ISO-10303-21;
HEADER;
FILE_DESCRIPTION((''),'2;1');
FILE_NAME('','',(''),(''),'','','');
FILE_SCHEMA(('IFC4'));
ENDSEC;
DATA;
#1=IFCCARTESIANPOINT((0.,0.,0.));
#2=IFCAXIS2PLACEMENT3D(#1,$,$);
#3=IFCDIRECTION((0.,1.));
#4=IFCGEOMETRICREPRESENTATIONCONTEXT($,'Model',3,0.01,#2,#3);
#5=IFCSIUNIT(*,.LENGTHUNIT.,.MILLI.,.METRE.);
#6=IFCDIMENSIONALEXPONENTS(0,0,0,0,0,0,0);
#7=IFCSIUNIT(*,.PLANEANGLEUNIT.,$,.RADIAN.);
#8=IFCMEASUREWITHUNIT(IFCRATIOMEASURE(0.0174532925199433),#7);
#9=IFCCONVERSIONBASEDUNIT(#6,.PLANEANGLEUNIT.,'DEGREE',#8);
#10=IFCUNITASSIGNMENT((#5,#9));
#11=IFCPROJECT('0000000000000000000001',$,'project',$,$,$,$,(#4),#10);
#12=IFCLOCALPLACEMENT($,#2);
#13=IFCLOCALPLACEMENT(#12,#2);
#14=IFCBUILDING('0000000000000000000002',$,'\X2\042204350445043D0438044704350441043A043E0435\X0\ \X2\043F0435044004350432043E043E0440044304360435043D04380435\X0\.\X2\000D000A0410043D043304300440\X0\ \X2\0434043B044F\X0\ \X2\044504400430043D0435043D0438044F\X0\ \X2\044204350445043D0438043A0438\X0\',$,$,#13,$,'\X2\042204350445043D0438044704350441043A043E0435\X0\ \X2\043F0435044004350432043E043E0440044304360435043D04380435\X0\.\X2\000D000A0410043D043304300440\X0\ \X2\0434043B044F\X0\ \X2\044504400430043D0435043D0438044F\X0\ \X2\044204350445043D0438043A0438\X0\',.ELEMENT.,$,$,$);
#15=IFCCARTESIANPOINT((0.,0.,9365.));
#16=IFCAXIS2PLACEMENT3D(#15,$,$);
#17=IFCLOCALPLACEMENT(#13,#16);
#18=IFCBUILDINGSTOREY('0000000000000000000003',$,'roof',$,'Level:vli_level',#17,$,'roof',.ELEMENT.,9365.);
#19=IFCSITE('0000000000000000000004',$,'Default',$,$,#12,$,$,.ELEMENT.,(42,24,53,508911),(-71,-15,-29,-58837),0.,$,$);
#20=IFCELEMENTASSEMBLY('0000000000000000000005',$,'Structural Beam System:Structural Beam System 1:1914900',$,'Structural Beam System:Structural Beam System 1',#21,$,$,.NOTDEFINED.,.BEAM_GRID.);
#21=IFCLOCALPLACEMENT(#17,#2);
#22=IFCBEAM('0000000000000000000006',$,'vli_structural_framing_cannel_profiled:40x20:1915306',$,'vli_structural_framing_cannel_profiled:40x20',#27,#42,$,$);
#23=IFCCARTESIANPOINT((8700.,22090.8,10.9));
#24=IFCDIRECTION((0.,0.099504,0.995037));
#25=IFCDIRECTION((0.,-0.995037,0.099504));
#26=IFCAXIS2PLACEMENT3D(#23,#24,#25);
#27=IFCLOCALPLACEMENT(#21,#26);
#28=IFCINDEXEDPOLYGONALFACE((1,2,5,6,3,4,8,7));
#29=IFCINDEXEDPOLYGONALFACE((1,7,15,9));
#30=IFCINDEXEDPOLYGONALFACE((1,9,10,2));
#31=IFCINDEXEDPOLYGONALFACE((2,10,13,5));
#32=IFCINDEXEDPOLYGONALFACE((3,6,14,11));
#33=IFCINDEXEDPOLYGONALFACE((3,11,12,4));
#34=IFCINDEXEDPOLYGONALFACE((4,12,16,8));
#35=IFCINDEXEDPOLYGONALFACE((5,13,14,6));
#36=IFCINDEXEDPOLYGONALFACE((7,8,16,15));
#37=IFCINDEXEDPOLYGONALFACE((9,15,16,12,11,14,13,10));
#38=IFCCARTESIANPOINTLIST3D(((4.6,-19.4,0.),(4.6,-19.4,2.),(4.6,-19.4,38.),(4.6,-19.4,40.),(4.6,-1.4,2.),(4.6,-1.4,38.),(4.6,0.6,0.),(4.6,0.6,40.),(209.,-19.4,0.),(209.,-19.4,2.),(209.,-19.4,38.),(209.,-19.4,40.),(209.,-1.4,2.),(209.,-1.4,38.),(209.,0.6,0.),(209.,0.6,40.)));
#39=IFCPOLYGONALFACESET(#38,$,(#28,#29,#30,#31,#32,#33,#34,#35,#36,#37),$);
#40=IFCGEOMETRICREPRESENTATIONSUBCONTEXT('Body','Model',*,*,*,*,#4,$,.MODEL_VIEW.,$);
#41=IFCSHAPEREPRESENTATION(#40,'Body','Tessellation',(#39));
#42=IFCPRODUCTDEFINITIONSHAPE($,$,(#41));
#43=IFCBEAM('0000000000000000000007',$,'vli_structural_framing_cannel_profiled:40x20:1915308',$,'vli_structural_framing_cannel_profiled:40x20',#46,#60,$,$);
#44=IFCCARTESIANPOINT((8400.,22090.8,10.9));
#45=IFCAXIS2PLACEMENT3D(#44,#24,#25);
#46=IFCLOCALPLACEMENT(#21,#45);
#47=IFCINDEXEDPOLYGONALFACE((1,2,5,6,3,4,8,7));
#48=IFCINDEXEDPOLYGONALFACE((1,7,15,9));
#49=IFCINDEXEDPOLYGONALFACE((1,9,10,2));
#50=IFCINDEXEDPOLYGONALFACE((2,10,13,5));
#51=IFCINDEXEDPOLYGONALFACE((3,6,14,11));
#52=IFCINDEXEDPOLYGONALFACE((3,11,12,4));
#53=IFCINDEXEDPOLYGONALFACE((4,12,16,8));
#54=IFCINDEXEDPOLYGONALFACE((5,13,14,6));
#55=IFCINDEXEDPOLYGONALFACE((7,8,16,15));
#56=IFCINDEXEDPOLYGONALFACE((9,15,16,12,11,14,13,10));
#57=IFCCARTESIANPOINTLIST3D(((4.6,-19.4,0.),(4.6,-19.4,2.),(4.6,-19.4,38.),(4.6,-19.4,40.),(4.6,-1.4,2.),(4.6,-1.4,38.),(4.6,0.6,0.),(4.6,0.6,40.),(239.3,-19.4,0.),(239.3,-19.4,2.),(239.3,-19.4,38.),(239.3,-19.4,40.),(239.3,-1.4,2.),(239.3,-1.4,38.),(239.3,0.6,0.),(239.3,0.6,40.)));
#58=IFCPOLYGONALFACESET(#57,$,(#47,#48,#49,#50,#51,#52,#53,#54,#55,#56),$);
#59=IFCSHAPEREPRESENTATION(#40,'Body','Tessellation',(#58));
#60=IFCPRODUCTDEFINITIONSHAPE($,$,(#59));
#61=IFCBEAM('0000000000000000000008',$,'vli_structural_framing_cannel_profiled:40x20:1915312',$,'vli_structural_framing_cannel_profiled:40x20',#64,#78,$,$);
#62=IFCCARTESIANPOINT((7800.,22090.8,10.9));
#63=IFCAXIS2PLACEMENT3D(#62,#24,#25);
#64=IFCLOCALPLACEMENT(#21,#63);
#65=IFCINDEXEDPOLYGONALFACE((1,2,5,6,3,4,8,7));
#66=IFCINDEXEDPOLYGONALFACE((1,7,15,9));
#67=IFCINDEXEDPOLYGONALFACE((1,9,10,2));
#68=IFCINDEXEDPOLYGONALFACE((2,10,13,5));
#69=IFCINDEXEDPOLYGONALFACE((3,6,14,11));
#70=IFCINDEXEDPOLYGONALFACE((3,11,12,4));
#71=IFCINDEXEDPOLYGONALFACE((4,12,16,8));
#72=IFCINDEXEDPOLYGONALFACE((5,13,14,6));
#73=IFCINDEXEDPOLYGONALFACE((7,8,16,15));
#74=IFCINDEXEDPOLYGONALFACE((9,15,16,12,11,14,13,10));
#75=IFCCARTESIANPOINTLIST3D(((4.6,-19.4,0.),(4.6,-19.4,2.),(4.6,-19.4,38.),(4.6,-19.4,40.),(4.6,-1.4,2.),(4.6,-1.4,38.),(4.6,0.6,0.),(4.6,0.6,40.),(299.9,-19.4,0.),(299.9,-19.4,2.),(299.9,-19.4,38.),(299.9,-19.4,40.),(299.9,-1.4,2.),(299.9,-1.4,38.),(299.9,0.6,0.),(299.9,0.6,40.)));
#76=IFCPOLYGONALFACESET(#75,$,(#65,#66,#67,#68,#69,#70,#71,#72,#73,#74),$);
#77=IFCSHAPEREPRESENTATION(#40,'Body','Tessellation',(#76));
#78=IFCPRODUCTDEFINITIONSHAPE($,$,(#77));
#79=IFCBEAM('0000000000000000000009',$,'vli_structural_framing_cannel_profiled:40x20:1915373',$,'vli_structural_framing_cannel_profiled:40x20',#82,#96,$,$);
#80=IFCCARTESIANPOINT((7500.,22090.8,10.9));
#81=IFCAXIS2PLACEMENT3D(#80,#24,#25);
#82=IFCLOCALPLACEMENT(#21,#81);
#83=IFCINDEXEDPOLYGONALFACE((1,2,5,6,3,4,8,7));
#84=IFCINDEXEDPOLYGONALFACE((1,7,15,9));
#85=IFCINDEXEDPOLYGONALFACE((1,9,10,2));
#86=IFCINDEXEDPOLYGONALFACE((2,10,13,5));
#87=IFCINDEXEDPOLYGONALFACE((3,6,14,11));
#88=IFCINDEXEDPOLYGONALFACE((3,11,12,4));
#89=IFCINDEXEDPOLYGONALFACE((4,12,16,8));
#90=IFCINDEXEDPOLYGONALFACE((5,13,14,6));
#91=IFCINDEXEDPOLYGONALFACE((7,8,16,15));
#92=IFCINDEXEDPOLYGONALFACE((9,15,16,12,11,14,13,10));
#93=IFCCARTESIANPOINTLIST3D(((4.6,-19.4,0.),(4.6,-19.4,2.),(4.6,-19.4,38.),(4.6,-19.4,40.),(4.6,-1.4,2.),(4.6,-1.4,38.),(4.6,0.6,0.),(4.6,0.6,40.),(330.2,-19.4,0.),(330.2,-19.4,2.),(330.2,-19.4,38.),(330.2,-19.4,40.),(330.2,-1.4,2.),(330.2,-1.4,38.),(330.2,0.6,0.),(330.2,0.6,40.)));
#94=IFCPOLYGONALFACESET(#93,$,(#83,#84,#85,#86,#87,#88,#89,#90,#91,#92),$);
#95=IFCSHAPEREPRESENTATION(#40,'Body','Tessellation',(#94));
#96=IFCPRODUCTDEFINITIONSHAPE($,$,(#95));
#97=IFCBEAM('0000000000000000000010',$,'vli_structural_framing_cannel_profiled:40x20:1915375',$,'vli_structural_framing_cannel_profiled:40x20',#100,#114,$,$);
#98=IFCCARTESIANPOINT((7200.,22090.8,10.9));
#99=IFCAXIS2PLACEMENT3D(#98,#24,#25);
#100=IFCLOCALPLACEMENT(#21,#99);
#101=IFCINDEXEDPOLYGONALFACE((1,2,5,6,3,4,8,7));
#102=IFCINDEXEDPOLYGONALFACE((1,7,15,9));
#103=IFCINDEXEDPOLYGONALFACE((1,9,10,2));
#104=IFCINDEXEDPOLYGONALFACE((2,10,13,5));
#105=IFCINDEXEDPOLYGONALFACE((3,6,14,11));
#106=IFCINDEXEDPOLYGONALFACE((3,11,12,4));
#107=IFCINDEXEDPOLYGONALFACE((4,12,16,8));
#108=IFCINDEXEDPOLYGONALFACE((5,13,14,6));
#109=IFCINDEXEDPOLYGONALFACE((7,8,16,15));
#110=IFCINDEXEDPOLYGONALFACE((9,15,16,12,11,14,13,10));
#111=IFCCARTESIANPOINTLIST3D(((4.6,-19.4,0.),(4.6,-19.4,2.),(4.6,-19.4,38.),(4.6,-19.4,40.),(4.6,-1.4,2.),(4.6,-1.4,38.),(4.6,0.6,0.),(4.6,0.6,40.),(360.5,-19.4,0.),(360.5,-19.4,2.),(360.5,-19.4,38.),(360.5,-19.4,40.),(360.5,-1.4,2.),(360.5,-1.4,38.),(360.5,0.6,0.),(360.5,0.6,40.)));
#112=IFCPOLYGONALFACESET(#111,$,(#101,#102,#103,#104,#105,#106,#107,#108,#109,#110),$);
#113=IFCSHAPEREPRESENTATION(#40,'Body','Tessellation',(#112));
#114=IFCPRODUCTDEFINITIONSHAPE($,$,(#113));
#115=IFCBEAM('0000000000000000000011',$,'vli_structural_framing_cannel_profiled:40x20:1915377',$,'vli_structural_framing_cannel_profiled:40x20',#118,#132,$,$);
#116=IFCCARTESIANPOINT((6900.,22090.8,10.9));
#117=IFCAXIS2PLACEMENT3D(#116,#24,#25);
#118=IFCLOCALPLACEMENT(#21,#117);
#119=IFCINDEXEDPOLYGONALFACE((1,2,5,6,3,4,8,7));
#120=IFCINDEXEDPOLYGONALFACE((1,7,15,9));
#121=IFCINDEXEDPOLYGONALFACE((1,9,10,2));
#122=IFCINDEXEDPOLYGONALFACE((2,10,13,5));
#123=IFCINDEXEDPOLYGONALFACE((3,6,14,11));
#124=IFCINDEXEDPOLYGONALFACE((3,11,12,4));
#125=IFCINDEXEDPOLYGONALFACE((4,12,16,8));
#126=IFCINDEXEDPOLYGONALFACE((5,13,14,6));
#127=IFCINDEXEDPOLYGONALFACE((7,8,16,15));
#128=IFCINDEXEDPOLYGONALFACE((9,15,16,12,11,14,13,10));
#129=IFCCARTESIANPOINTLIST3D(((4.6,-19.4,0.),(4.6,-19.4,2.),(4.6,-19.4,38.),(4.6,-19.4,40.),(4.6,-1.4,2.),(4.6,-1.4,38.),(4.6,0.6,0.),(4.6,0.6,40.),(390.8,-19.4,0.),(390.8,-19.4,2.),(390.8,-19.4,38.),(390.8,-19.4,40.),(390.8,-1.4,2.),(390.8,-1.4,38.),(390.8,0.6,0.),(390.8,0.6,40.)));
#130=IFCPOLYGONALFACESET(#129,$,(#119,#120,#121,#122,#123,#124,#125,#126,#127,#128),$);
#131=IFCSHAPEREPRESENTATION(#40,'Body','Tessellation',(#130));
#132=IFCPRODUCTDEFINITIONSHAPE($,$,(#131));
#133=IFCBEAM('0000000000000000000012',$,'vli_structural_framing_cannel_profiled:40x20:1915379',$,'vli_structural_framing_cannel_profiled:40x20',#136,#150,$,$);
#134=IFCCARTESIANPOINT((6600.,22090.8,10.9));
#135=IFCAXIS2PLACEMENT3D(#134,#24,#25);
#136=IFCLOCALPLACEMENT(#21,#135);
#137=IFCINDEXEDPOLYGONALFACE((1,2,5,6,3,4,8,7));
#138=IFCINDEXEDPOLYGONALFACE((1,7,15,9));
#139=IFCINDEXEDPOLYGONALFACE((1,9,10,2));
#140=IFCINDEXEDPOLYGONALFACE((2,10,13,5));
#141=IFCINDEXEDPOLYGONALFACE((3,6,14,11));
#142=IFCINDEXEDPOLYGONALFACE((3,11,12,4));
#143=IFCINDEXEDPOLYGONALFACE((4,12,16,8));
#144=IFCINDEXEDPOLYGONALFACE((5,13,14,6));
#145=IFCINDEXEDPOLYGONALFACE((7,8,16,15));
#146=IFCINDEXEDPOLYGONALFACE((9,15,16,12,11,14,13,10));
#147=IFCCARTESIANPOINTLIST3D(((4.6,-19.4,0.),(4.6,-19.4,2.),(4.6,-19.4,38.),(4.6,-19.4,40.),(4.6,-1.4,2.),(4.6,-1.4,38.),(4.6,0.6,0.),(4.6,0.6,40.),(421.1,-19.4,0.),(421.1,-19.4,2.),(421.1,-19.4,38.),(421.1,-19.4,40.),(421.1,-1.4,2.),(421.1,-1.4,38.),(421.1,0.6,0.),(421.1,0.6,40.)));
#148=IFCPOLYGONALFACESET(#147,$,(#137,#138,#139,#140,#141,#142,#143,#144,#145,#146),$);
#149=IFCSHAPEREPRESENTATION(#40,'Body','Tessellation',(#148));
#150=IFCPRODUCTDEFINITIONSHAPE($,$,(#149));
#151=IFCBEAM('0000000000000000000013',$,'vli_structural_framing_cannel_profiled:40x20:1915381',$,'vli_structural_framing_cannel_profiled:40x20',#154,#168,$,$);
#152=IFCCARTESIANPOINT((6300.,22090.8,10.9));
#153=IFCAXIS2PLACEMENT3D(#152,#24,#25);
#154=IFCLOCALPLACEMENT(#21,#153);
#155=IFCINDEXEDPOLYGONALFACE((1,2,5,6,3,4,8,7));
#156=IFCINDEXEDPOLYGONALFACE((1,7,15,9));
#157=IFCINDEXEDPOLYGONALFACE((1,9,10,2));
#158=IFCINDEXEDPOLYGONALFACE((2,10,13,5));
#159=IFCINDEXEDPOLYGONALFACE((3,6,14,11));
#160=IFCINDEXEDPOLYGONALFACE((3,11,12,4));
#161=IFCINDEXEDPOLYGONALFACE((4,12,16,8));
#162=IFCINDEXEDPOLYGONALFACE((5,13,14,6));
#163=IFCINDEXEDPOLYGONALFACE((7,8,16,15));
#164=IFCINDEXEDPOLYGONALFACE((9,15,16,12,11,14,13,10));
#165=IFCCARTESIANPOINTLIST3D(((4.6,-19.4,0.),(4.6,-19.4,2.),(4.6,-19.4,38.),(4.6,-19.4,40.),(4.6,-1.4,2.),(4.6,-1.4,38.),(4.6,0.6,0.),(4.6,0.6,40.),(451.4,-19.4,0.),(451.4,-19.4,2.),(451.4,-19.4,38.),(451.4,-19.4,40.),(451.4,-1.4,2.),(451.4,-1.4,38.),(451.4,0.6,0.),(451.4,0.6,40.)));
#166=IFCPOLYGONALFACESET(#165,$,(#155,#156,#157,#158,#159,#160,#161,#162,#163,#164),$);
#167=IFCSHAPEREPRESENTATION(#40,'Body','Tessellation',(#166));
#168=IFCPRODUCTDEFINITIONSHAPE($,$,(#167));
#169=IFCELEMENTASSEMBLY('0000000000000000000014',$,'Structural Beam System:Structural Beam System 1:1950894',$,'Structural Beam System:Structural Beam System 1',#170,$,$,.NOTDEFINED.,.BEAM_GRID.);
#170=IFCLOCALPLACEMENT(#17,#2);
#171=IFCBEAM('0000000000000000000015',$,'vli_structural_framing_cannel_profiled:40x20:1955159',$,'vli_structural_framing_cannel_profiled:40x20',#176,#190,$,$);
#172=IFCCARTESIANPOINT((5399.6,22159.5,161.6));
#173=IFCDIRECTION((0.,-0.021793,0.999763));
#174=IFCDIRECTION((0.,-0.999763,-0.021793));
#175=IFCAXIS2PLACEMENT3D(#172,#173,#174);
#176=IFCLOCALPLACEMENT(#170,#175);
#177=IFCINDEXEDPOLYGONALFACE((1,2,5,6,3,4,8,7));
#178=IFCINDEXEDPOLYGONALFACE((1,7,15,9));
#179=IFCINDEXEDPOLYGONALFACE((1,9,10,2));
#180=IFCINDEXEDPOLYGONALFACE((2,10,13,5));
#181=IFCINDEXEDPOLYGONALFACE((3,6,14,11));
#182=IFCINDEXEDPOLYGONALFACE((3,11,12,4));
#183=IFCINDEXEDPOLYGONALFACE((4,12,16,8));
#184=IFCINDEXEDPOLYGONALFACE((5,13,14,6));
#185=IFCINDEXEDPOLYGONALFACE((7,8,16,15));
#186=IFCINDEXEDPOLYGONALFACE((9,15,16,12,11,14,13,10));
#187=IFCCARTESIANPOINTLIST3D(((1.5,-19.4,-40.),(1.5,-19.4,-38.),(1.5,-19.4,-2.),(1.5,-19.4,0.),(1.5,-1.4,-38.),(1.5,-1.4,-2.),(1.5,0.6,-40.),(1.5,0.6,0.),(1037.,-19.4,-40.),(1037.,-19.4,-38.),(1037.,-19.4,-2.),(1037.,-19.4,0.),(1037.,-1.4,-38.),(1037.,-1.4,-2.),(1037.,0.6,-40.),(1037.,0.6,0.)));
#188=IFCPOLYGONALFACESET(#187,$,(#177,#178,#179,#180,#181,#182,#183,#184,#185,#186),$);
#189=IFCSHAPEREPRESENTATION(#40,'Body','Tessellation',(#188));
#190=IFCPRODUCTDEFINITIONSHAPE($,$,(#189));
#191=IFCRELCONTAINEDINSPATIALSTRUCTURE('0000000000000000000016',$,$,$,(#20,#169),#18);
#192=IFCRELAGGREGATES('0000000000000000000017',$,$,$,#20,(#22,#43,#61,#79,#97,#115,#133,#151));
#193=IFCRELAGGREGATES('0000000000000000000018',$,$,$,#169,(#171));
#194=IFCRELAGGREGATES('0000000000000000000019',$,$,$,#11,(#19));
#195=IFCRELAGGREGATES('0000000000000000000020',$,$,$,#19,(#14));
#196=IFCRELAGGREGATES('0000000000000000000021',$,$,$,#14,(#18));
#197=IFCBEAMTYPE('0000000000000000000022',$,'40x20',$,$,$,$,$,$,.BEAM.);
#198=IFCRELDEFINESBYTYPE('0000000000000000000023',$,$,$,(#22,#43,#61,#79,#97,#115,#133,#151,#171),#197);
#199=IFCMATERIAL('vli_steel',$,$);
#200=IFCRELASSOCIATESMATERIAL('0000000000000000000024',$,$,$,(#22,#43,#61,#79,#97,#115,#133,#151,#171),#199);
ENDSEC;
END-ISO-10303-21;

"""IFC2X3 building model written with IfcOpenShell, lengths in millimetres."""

from ifc_helpers import new_model, entity, si_unit, converted_unit, direction, frame, origin, place, context, subcontext, project, spatial, polyline, outline, extrude, material, type_object, element, aggregate, save


model = new_model("IFC2X3")

# Units and contexts
model_context = context("Model", 3, precision=0.01, world=origin(), true_north=direction((0.0, 1.0)))
body_context = subcontext(model_context, "Body", "Model", "MODEL_VIEW")
ifc_project = project(units=[si_unit("LENGTHUNIT", "METRE", prefix="MILLI"), converted_unit("PLANEANGLEUNIT", "DEGREE", entity("IfcRatioMeasure", 0.0174532925199433), si_unit("PLANEANGLEUNIT", "RADIAN"), dimensions=[0, 0, 0, 0, 0, 0, 0])], contexts=[model_context])

# Site, building, storey
site_placement = place(None, origin())
site = spatial("IfcSite", under=ifc_project, at=site_placement, Name="Default", CompositionType="ELEMENT", RefLatitude=(42, 24, 53, 508911), RefLongitude=(-71, -15, -29, -58837), RefElevation=0.0)
building_placement = place(site_placement, origin())
building = spatial("IfcBuilding", under=site, at=building_placement, Name="Техническое перевооружение.\r\nАнгар для хранения техники", LongName="Техническое перевооружение.\r\nАнгар для хранения техники", CompositionType="ELEMENT")
storey_placement = place(building_placement, frame((0.0, 0.0, 9365.0)))
storey = spatial("IfcBuildingStorey", under=building, at=storey_placement, Name="roof", ObjectType="Level:vli_level", LongName="roof", CompositionType="ELEMENT", Elevation=9365.0)

# Element assemblies, beams
assembly_1_placement = place(storey_placement, origin())
assembly_1 = element("IfcElementAssembly", 1, at=assembly_1_placement, inside=storey, Name="Structural Beam System:Structural Beam System 1:1914900", ObjectType="Structural Beam System:Structural Beam System 1", AssemblyPlace="NOTDEFINED", PredefinedType="BEAM_GRID")
ifc_material = material(Name="vli_steel")
beam_type = type_object("IfcBeamType", Name="40x20", PredefinedType="BEAM")
beam_1_placement = place(assembly_1_placement, frame((8700.0, 22090.8, 10.9), z_axis=(0.0, 0.099504, 0.995037), x_axis=(0.0, -0.995037, 0.099504)))
beam_1 = element("IfcBeam", 2, at=beam_1_placement, type_object=beam_type, material=ifc_material, Name="vli_structural_framing_cannel_profiled:40x20:1915306", ObjectType="vli_structural_framing_cannel_profiled:40x20", context=body_context, shape_type="SweptSolid", body=[
    extrude(outline(polyline([(-20.0, -9.5), (-18.0, -9.5), (-18.0, 8.5), (18.0, 8.5), (18.0, -9.5), (20.0, -9.5), (20.0, 10.5), (-20.0, 10.5), (-20.0, -9.5)])), frame((4.6, -9.9, 20.0), z_axis=(1.0, 0.0, 0.0), x_axis=(0.0, 0.0, -1.0)), (0.0, 0.0, 1.0), 204.4),
])
beam_2_placement = place(assembly_1_placement, frame((8400.0, 22090.8, 10.9), z_axis=(0.0, 0.099504, 0.995037), x_axis=(0.0, -0.995037, 0.099504)))
beam_2 = element("IfcBeam", 3, at=beam_2_placement, type_object=beam_type, material=ifc_material, Name="vli_structural_framing_cannel_profiled:40x20:1915308", ObjectType="vli_structural_framing_cannel_profiled:40x20", context=body_context, shape_type="SweptSolid", body=[
    extrude(outline(polyline([(-20.0, -9.5), (-18.0, -9.5), (-18.0, 8.5), (18.0, 8.5), (18.0, -9.5), (20.0, -9.5), (20.0, 10.5), (-20.0, 10.5), (-20.0, -9.5)])), frame((4.6, -9.9, 20.0), z_axis=(1.0, 0.0, 0.0), x_axis=(0.0, 0.0, -1.0)), (0.0, 0.0, 1.0), 234.7),
])
beam_3_placement = place(assembly_1_placement, frame((7800.0, 22090.8, 10.9), z_axis=(0.0, 0.099504, 0.995037), x_axis=(0.0, -0.995037, 0.099504)))
beam_3 = element("IfcBeam", 4, at=beam_3_placement, type_object=beam_type, material=ifc_material, Name="vli_structural_framing_cannel_profiled:40x20:1915312", ObjectType="vli_structural_framing_cannel_profiled:40x20", context=body_context, shape_type="SweptSolid", body=[
    extrude(outline(polyline([(-20.0, -9.5), (-18.0, -9.5), (-18.0, 8.5), (18.0, 8.5), (18.0, -9.5), (20.0, -9.5), (20.0, 10.5), (-20.0, 10.5), (-20.0, -9.5)])), frame((4.6, -9.9, 20.0), z_axis=(1.0, 0.0, 0.0), x_axis=(0.0, 0.0, -1.0)), (0.0, 0.0, 1.0), 295.3),
])
beam_4_placement = place(assembly_1_placement, frame((7500.0, 22090.8, 10.9), z_axis=(0.0, 0.099504, 0.995037), x_axis=(0.0, -0.995037, 0.099504)))
beam_4 = element("IfcBeam", 5, at=beam_4_placement, type_object=beam_type, material=ifc_material, Name="vli_structural_framing_cannel_profiled:40x20:1915373", ObjectType="vli_structural_framing_cannel_profiled:40x20", context=body_context, shape_type="SweptSolid", body=[
    extrude(outline(polyline([(-20.0, -9.5), (-18.0, -9.5), (-18.0, 8.5), (18.0, 8.5), (18.0, -9.5), (20.0, -9.5), (20.0, 10.5), (-20.0, 10.5), (-20.0, -9.5)])), frame((4.6, -9.9, 20.0), z_axis=(1.0, 0.0, 0.0), x_axis=(0.0, 0.0, -1.0)), (0.0, 0.0, 1.0), 325.6),
])
beam_5_placement = place(assembly_1_placement, frame((7200.0, 22090.8, 10.9), z_axis=(0.0, 0.099504, 0.995037), x_axis=(0.0, -0.995037, 0.099504)))
beam_5 = element("IfcBeam", 6, at=beam_5_placement, type_object=beam_type, material=ifc_material, Name="vli_structural_framing_cannel_profiled:40x20:1915375", ObjectType="vli_structural_framing_cannel_profiled:40x20", context=body_context, shape_type="SweptSolid", body=[
    extrude(outline(polyline([(-20.0, -9.5), (-18.0, -9.5), (-18.0, 8.5), (18.0, 8.5), (18.0, -9.5), (20.0, -9.5), (20.0, 10.5), (-20.0, 10.5), (-20.0, -9.5)])), frame((4.6, -9.9, 20.0), z_axis=(1.0, 0.0, 0.0), x_axis=(0.0, 0.0, -1.0)), (0.0, 0.0, 1.0), 355.9),
])
beam_6_placement = place(assembly_1_placement, frame((6900.0, 22090.8, 10.9), z_axis=(0.0, 0.099504, 0.995037), x_axis=(0.0, -0.995037, 0.099504)))
beam_6 = element("IfcBeam", 7, at=beam_6_placement, type_object=beam_type, material=ifc_material, Name="vli_structural_framing_cannel_profiled:40x20:1915377", ObjectType="vli_structural_framing_cannel_profiled:40x20", context=body_context, shape_type="SweptSolid", body=[
    extrude(outline(polyline([(-20.0, -9.5), (-18.0, -9.5), (-18.0, 8.5), (18.0, 8.5), (18.0, -9.5), (20.0, -9.5), (20.0, 10.5), (-20.0, 10.5), (-20.0, -9.5)])), frame((4.6, -9.9, 20.0), z_axis=(1.0, 0.0, 0.0), x_axis=(0.0, 0.0, -1.0)), (0.0, 0.0, 1.0), 386.2),
])
beam_7_placement = place(assembly_1_placement, frame((6600.0, 22090.8, 10.9), z_axis=(0.0, 0.099504, 0.995037), x_axis=(0.0, -0.995037, 0.099504)))
beam_7 = element("IfcBeam", 8, at=beam_7_placement, type_object=beam_type, material=ifc_material, Name="vli_structural_framing_cannel_profiled:40x20:1915379", ObjectType="vli_structural_framing_cannel_profiled:40x20", context=body_context, shape_type="SweptSolid", body=[
    extrude(outline(polyline([(-20.0, -9.5), (-18.0, -9.5), (-18.0, 8.5), (18.0, 8.5), (18.0, -9.5), (20.0, -9.5), (20.0, 10.5), (-20.0, 10.5), (-20.0, -9.5)])), frame((4.6, -9.9, 20.0), z_axis=(1.0, 0.0, 0.0), x_axis=(0.0, 0.0, -1.0)), (0.0, 0.0, 1.0), 416.5),
])
beam_8_placement = place(assembly_1_placement, frame((6300.0, 22090.8, 10.9), z_axis=(0.0, 0.099504, 0.995037), x_axis=(0.0, -0.995037, 0.099504)))
beam_8 = element("IfcBeam", 9, at=beam_8_placement, type_object=beam_type, material=ifc_material, Name="vli_structural_framing_cannel_profiled:40x20:1915381", ObjectType="vli_structural_framing_cannel_profiled:40x20", context=body_context, shape_type="SweptSolid", body=[
    extrude(outline(polyline([(-20.0, -9.5), (-18.0, -9.5), (-18.0, 8.5), (18.0, 8.5), (18.0, -9.5), (20.0, -9.5), (20.0, 10.5), (-20.0, 10.5), (-20.0, -9.5)])), frame((4.6, -9.9, 20.0), z_axis=(1.0, 0.0, 0.0), x_axis=(0.0, 0.0, -1.0)), (0.0, 0.0, 1.0), 446.8),
])
aggregate(assembly_1, [beam_1, beam_2, beam_3, beam_4, beam_5, beam_6, beam_7, beam_8])
assembly_2_placement = place(storey_placement, origin())
assembly_2 = element("IfcElementAssembly", 10, at=assembly_2_placement, inside=storey, Name="Structural Beam System:Structural Beam System 1:1950894", ObjectType="Structural Beam System:Structural Beam System 1", AssemblyPlace="NOTDEFINED", PredefinedType="BEAM_GRID")
beam_9_placement = place(assembly_2_placement, frame((5399.6, 22159.5, 161.6), z_axis=(0.0, -0.021793, 0.999763), x_axis=(0.0, -0.999763, -0.021793)))
beam_9 = element("IfcBeam", 11, at=beam_9_placement, type_object=beam_type, material=ifc_material, Name="vli_structural_framing_cannel_profiled:40x20:1955159", ObjectType="vli_structural_framing_cannel_profiled:40x20", context=body_context, shape_type="SweptSolid", body=[
    extrude(outline(polyline([(-20.0, -9.5), (-18.0, -9.5), (-18.0, 8.5), (18.0, 8.5), (18.0, -9.5), (20.0, -9.5), (20.0, 10.5), (-20.0, 10.5), (-20.0, -9.5)])), frame((1.5, -9.9, -20.0), z_axis=(1.0, 0.0, 0.0), x_axis=(0.0, 0.0, -1.0)), (0.0, 0.0, 1.0), 1035.5),
])
aggregate(assembly_2, [beam_9])

save(model, "model.ifc")
